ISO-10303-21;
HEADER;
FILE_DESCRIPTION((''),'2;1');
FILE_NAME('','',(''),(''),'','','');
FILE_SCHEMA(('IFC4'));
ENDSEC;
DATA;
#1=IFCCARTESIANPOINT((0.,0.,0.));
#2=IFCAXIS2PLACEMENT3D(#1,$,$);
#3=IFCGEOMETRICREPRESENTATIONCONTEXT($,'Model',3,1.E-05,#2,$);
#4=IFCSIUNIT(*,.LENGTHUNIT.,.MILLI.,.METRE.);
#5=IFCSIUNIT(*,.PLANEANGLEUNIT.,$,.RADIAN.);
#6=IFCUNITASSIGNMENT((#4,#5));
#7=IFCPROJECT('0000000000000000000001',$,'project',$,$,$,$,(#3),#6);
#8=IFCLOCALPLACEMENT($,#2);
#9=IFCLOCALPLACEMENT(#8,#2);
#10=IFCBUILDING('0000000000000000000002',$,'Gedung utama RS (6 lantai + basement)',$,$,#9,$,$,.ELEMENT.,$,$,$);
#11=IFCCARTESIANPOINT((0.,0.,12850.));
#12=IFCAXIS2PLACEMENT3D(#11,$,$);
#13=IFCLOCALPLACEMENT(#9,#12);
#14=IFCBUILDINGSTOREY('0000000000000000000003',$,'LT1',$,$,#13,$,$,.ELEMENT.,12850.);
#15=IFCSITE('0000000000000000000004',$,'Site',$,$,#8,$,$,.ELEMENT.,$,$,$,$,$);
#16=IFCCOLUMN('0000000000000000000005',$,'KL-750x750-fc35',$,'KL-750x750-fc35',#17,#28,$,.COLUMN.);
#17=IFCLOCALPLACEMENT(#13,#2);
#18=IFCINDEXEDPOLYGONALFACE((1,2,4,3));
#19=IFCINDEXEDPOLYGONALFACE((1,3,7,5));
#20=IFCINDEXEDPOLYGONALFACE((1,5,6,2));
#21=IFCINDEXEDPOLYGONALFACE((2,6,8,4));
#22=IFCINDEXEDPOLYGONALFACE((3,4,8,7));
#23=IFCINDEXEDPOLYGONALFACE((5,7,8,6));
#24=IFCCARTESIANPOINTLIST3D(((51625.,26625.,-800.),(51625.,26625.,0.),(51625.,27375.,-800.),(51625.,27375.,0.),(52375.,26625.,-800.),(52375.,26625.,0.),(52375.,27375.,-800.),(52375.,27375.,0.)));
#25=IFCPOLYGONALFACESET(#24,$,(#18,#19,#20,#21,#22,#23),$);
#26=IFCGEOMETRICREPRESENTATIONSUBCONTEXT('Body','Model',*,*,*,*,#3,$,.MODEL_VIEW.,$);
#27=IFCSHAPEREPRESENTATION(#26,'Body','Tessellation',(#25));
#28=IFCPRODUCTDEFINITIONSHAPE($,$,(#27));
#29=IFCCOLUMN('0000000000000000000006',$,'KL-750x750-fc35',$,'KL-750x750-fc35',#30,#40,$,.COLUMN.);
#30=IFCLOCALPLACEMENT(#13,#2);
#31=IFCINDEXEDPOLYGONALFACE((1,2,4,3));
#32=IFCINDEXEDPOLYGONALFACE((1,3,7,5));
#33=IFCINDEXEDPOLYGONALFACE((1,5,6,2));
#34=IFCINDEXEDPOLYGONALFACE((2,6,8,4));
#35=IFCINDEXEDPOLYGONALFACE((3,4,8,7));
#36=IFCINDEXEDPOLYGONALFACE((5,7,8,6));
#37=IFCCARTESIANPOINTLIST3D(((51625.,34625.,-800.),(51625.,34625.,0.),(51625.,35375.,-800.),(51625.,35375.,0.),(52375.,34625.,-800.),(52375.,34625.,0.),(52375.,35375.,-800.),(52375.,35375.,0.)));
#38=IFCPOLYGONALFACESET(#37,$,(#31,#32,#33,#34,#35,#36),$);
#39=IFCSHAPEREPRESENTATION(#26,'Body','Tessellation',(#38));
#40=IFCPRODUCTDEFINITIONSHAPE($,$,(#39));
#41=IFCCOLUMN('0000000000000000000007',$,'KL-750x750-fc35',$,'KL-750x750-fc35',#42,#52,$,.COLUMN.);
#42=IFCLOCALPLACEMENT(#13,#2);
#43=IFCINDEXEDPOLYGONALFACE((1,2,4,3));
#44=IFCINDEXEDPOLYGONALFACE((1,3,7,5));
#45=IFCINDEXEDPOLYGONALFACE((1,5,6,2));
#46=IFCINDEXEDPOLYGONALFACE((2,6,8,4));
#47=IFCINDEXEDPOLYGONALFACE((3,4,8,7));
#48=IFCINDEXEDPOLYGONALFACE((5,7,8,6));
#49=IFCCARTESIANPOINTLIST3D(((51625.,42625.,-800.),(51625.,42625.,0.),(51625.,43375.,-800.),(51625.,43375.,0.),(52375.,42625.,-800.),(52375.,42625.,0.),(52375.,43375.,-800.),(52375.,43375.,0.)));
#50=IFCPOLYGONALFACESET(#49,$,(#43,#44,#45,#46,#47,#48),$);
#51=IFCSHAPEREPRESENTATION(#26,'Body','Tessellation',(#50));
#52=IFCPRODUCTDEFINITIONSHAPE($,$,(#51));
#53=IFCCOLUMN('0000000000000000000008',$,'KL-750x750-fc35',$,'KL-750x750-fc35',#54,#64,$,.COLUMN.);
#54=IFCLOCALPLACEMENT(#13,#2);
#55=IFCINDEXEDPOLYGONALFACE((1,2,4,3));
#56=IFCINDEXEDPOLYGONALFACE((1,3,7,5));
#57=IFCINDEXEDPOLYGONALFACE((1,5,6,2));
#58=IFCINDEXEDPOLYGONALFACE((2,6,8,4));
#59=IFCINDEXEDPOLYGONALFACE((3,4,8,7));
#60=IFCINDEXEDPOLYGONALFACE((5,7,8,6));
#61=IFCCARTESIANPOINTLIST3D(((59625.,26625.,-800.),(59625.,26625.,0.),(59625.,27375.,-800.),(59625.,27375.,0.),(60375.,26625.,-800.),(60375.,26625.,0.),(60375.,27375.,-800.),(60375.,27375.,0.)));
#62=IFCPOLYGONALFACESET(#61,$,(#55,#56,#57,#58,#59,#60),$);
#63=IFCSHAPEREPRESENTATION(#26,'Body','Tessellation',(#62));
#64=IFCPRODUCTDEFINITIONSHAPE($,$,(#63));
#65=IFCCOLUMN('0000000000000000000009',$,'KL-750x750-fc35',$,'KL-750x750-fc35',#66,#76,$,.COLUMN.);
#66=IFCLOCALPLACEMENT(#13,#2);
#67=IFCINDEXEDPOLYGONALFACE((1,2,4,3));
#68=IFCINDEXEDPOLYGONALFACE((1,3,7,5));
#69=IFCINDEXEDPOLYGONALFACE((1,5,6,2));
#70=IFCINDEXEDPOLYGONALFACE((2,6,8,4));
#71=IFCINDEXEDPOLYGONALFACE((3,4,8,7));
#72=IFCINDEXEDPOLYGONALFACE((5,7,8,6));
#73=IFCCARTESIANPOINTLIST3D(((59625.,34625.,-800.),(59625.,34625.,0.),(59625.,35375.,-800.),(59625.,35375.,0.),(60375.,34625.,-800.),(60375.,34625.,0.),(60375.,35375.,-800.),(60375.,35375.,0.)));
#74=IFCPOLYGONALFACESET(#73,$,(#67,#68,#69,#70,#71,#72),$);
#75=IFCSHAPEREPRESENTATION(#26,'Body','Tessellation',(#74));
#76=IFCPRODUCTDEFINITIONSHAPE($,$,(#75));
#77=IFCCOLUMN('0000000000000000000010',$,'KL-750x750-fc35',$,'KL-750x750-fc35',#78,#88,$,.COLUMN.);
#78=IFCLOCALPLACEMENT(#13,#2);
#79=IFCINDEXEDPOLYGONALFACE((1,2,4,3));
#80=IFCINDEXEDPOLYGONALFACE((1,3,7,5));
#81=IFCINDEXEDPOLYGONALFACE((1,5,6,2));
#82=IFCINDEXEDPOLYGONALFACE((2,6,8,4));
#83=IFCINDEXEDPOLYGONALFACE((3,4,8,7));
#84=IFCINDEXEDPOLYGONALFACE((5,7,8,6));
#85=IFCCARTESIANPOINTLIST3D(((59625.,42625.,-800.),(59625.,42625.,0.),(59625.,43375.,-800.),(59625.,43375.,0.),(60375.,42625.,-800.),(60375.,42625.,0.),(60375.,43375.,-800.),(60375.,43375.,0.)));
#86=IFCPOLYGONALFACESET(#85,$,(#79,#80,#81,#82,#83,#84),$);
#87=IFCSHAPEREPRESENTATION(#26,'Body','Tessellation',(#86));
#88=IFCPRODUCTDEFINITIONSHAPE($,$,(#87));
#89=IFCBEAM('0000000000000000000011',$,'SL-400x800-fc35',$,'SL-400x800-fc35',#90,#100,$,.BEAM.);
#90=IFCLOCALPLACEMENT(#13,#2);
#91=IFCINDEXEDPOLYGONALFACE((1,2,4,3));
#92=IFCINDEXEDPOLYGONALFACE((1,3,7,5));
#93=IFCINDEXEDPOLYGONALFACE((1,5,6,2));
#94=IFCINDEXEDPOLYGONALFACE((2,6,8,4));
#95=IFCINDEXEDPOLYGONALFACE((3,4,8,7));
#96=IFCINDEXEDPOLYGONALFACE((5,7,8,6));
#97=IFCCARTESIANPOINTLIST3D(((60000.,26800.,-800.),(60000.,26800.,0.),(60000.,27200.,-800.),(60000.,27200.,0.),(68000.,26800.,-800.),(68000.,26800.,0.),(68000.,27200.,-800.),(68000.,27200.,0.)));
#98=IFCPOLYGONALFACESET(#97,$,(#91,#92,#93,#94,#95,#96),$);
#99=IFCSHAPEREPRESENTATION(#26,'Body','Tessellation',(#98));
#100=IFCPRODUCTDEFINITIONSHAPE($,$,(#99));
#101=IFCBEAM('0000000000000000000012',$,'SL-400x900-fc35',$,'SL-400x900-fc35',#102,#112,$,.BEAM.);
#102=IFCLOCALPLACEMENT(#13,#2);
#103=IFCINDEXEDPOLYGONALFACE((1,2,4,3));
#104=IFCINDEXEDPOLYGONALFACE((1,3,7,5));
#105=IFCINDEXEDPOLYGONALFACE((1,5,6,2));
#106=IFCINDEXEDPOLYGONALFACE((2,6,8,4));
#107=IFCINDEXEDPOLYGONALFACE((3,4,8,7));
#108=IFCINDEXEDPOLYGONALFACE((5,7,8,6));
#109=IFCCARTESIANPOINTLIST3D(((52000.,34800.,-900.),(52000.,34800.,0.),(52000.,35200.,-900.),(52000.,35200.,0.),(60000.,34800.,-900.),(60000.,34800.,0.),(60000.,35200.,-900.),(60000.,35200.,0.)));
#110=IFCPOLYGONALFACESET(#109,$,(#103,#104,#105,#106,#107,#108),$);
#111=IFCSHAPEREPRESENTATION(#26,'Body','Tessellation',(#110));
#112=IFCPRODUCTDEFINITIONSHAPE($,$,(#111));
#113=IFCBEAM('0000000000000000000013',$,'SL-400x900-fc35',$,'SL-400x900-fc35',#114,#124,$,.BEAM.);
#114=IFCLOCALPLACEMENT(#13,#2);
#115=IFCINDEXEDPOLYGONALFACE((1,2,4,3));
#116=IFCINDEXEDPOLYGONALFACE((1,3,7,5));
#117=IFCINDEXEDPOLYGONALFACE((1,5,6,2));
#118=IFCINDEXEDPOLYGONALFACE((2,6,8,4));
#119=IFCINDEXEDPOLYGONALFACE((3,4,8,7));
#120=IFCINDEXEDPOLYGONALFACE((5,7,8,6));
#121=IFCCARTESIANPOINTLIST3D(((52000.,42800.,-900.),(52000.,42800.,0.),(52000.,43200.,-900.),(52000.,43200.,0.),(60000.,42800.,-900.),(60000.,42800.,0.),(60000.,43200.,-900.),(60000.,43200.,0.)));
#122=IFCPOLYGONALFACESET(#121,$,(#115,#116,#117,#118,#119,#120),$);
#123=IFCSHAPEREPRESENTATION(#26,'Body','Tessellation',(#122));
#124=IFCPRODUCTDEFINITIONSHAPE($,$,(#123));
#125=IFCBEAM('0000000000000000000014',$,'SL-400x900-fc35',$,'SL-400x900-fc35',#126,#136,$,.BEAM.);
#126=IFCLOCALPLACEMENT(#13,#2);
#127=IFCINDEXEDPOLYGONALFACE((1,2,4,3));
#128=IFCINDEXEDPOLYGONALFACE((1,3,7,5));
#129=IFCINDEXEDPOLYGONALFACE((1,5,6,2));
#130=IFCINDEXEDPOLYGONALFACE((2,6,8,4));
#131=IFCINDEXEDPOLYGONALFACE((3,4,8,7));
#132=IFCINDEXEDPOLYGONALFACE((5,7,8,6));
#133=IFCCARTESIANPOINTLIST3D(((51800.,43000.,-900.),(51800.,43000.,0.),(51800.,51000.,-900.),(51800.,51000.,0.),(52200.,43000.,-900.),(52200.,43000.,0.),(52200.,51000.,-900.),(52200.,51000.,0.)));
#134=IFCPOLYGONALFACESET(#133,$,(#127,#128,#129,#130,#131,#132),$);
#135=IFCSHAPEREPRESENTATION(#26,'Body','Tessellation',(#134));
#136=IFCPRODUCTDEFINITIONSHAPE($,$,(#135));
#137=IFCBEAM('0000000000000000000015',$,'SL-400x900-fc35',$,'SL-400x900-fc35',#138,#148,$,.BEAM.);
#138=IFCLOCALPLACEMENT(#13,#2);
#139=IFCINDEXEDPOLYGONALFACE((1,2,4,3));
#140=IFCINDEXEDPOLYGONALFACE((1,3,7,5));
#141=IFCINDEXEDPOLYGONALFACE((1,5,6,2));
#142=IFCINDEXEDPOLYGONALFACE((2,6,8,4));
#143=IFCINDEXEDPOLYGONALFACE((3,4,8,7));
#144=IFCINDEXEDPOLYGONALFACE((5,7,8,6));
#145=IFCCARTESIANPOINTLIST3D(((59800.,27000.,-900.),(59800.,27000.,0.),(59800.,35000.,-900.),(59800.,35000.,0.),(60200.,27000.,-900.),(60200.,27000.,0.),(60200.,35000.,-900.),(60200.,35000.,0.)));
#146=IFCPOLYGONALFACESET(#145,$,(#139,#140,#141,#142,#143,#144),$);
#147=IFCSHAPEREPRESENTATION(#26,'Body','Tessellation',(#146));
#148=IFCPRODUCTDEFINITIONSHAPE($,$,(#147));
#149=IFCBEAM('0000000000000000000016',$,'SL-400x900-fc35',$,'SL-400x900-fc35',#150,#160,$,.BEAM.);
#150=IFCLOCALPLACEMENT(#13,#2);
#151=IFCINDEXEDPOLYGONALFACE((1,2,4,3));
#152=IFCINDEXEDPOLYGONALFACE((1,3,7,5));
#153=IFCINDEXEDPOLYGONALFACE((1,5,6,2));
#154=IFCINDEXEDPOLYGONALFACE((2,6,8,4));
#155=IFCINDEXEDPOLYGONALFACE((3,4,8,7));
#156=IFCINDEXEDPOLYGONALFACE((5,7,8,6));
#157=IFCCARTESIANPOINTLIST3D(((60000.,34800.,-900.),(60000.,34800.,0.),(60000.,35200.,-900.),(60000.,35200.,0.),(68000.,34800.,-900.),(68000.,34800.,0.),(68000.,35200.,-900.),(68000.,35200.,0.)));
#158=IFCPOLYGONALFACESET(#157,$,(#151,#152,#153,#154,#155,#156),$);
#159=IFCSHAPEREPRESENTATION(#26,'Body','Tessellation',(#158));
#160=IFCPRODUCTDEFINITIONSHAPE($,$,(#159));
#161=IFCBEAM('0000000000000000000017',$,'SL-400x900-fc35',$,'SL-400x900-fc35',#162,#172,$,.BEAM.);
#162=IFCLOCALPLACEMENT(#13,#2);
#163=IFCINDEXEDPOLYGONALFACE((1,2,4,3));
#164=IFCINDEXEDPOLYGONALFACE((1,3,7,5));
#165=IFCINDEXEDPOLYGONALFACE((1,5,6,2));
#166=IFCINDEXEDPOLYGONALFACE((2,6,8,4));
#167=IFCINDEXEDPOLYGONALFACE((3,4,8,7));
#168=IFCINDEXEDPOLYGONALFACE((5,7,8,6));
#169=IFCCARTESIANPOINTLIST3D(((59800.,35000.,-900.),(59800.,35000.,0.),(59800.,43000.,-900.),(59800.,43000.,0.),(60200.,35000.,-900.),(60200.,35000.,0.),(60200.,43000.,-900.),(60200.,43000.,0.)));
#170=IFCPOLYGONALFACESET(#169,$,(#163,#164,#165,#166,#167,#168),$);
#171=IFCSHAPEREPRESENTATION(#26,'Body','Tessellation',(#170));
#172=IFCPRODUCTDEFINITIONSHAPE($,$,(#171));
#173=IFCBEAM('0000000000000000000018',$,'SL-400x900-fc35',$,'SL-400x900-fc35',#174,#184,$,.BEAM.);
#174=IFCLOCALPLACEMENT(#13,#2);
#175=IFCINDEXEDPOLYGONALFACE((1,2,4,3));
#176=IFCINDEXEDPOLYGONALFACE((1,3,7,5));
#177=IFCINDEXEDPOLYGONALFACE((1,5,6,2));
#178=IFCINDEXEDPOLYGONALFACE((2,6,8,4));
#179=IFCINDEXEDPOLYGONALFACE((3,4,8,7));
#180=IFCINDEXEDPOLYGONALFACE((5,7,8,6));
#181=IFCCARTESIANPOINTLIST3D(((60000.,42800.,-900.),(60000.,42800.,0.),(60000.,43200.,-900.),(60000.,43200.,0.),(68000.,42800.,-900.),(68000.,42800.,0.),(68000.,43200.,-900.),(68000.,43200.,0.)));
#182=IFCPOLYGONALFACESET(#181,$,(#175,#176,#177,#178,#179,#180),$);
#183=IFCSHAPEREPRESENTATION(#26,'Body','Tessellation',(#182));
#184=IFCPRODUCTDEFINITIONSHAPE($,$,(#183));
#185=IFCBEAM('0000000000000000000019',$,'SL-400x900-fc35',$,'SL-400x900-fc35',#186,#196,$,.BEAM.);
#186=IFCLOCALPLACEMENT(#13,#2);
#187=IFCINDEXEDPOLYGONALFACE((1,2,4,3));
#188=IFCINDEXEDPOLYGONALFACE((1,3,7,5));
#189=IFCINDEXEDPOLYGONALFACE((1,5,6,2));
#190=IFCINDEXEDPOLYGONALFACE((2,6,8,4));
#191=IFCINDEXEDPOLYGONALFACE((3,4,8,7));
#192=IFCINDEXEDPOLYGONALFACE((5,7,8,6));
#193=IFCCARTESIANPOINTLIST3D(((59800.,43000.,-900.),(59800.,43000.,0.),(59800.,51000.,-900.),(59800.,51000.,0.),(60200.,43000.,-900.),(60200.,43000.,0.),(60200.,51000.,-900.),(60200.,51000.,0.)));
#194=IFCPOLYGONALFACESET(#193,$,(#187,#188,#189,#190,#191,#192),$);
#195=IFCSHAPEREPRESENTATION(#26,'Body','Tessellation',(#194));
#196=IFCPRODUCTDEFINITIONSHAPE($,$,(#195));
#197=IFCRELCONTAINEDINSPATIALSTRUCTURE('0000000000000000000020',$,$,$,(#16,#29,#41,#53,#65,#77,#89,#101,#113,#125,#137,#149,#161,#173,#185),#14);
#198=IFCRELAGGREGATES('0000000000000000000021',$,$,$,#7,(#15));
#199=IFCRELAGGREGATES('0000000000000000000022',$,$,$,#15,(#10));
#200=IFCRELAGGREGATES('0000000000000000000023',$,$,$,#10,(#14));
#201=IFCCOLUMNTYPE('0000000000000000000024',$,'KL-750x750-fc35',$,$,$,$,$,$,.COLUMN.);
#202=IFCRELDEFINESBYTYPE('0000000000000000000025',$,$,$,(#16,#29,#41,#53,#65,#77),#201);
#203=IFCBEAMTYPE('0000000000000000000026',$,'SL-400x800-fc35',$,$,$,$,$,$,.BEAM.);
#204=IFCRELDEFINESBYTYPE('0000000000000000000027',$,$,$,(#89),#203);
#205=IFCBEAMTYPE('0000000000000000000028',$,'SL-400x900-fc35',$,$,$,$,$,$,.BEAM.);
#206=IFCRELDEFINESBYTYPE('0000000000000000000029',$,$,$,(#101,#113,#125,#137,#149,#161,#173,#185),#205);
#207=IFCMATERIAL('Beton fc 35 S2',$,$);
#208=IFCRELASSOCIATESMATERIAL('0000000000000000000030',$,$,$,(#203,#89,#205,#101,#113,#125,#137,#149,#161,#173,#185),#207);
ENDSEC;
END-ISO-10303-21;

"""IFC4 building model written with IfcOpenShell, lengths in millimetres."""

from ifc_helpers import new_model, si_unit, frame, origin, origin_2d, place, context, subcontext, project, spatial, rectangle, extrude, material, material_profile, profile_set, profile_usage, type_object, element, save


model = new_model("IFC4")

# Units and contexts
model_context = context("Model", 3, precision=1e-05, world=origin())
body_context = subcontext(model_context, "Body", "Model", "MODEL_VIEW")
ifc_project = project(units=[si_unit("LENGTHUNIT", "METRE", prefix="MILLI"), si_unit("PLANEANGLEUNIT", "RADIAN")], contexts=[model_context])

# Site, building, storey
site_placement = place(None, origin())
site = spatial("IfcSite", under=ifc_project, at=site_placement, Name="Site", CompositionType="ELEMENT")
building_placement = place(site_placement, origin())
building = spatial("IfcBuilding", under=site, at=building_placement, Name="Gedung utama RS (6 lantai + basement)", CompositionType="ELEMENT")
storey_placement = place(building_placement, frame((0.0, 0.0, 12850.0)))
storey = spatial("IfcBuildingStorey", under=building, at=storey_placement, Name="LT1", CompositionType="ELEMENT", Elevation=12850.0)

# Columns
ifc_material_profile_1 = material_profile(None, rectangle(XDim=750.0, YDim=750.0, at=origin_2d()), Name="KL-750x750-fc35")
ifc_profile_set_1 = profile_set([ifc_material_profile_1], Name="KL-750x750-fc35")
ifc_profile_usage_1 = profile_usage(ifc_profile_set_1, cardinal=5)
column_type = type_object("IfcColumnType", Name="KL-750x750-fc35", PredefinedType="COLUMN", material=ifc_profile_set_1)
for number, where, z_axis, x_axis, name in (
    (1, (52000.0, 27000.0, -800.0), (0.0, 0.0, 1.0), (1.0, 0.0, 0.0), "KL-750x750-fc35"),
    (2, (52000.0, 35000.0, -800.0), (0.0, 0.0, 1.0), (1.0, 0.0, 0.0), "KL-750x750-fc35"),
    (3, (52000.0, 43000.0, -800.0), (0.0, 0.0, 1.0), (1.0, 0.0, 0.0), "KL-750x750-fc35"),
    (4, (60000.0, 27000.0, -800.0), (0.0, 0.0, 1.0), (1.0, 0.0, 0.0), "KL-750x750-fc35"),
    (5, (60000.0, 35000.0, -800.0), (0.0, 0.0, 1.0), (1.0, 0.0, 0.0), "KL-750x750-fc35"),
    (6, (60000.0, 43000.0, -800.0), (0.0, 0.0, 1.0), (1.0, 0.0, 0.0), "KL-750x750-fc35"),
):
    element("IfcColumn", number, at=place(storey_placement, frame(where, z_axis=z_axis, x_axis=x_axis)), inside=storey, type_object=column_type, material=ifc_profile_usage_1, Name=name, ObjectType="KL-750x750-fc35", PredefinedType="COLUMN", context=body_context, shape_type="SweptSolid", body=[
        extrude(rectangle(XDim=750.0, YDim=750.0, at=origin_2d()), origin(), (0.0, 0.0, 1.0), 800.0),
    ])

# Beams
ifc_material = material(Name="Beton fc 35 S2")
ifc_material_profile_2 = material_profile(ifc_material, rectangle(XDim=400.0, YDim=800.0, at=origin_2d()), Name="SL-400x800-fc35")
ifc_profile_set_2 = profile_set([ifc_material_profile_2], Name="SL-400x800-fc35")
ifc_profile_usage_2 = profile_usage(ifc_profile_set_2, cardinal=8)
beam_type_1 = type_object("IfcBeamType", Name="SL-400x800-fc35", PredefinedType="BEAM", material=ifc_profile_set_2)
beam_1_placement = place(storey_placement, frame((60000.0, 27000.0, -400.0)))
element("IfcBeam", 7, at=beam_1_placement, inside=storey, type_object=beam_type_1, material=ifc_profile_usage_2, Name="SL-400x800-fc35", ObjectType="SL-400x800-fc35", PredefinedType="BEAM", context=body_context, shape_type="SweptSolid", body=[
    extrude(rectangle(XDim=400.0, YDim=800.0, at=origin_2d()), frame((0.0, 0.0, 0.0), z_axis=(1.0, 0.0, 0.0), x_axis=(0.0, 1.0, 0.0)), (0.0, 0.0, 1.0), 8000.0),
])
ifc_material_profile_3 = material_profile(ifc_material, rectangle(XDim=400.0, YDim=900.0, at=origin_2d()), Name="SL-400x900-fc35")
ifc_profile_set_3 = profile_set([ifc_material_profile_3], Name="SL-400x900-fc35")
ifc_profile_usage_3 = profile_usage(ifc_profile_set_3, cardinal=8)
beam_type_2 = type_object("IfcBeamType", Name="SL-400x900-fc35", PredefinedType="BEAM", material=ifc_profile_set_3)
for number, where, name in (
    (8, (52000.0, 35000.0, -450.0), "SL-400x900-fc35"),
    (9, (52000.0, 43000.0, -450.0), "SL-400x900-fc35"),
):
    element("IfcBeam", number, at=place(storey_placement, frame(where)), inside=storey, type_object=beam_type_2, material=ifc_profile_usage_3, Name=name, ObjectType="SL-400x900-fc35", PredefinedType="BEAM", context=body_context, shape_type="SweptSolid", body=[
        extrude(rectangle(XDim=400.0, YDim=900.0, at=origin_2d()), frame((0.0, 0.0, 0.0), z_axis=(1.0, 0.0, 0.0), x_axis=(0.0, 1.0, 0.0)), (0.0, 0.0, 1.0), 8000.0),
    ])
for number, where, name in (
    (10, (52000.0, 43000.0, -450.0), "SL-400x900-fc35"),
    (11, (60000.0, 27000.0, -450.0), "SL-400x900-fc35"),
):
    element("IfcBeam", number, at=place(storey_placement, frame(where)), inside=storey, type_object=beam_type_2, material=ifc_profile_usage_3, Name=name, ObjectType="SL-400x900-fc35", PredefinedType="BEAM", context=body_context, shape_type="SweptSolid", body=[
        extrude(rectangle(XDim=400.0, YDim=900.0, at=origin_2d()), frame((0.0, 0.0, 0.0), z_axis=(0.0, 1.0, 0.0), x_axis=(-1.0, 0.0, 0.0)), (0.0, 0.0, 1.0), 8000.0),
    ])
beam_2_placement = place(storey_placement, frame((60000.0, 35000.0, -450.0)))
element("IfcBeam", 12, at=beam_2_placement, inside=storey, type_object=beam_type_2, material=ifc_profile_usage_3, Name="SL-400x900-fc35", ObjectType="SL-400x900-fc35", PredefinedType="BEAM", context=body_context, shape_type="SweptSolid", body=[
    extrude(rectangle(XDim=400.0, YDim=900.0, at=origin_2d()), frame((0.0, 0.0, 0.0), z_axis=(1.0, 0.0, 0.0), x_axis=(0.0, 1.0, 0.0)), (0.0, 0.0, 1.0), 8000.0),
])
beam_3_placement = place(storey_placement, frame((60000.0, 35000.0, -450.0)))
element("IfcBeam", 13, at=beam_3_placement, inside=storey, type_object=beam_type_2, material=ifc_profile_usage_3, Name="SL-400x900-fc35", ObjectType="SL-400x900-fc35", PredefinedType="BEAM", context=body_context, shape_type="SweptSolid", body=[
    extrude(rectangle(XDim=400.0, YDim=900.0, at=origin_2d()), frame((0.0, 0.0, 0.0), z_axis=(0.0, 1.0, 0.0), x_axis=(-1.0, 0.0, 0.0)), (0.0, 0.0, 1.0), 8000.0),
])
beam_4_placement = place(storey_placement, frame((60000.0, 43000.0, -450.0)))
element("IfcBeam", 14, at=beam_4_placement, inside=storey, type_object=beam_type_2, material=ifc_profile_usage_3, Name="SL-400x900-fc35", ObjectType="SL-400x900-fc35", PredefinedType="BEAM", context=body_context, shape_type="SweptSolid", body=[
    extrude(rectangle(XDim=400.0, YDim=900.0, at=origin_2d()), frame((0.0, 0.0, 0.0), z_axis=(1.0, 0.0, 0.0), x_axis=(0.0, 1.0, 0.0)), (0.0, 0.0, 1.0), 8000.0),
])
beam_5_placement = place(storey_placement, frame((60000.0, 43000.0, -450.0)))
element("IfcBeam", 15, at=beam_5_placement, inside=storey, type_object=beam_type_2, material=ifc_profile_usage_3, Name="SL-400x900-fc35", ObjectType="SL-400x900-fc35", PredefinedType="BEAM", context=body_context, shape_type="SweptSolid", body=[
    extrude(rectangle(XDim=400.0, YDim=900.0, at=origin_2d()), frame((0.0, 0.0, 0.0), z_axis=(0.0, 1.0, 0.0), x_axis=(-1.0, 0.0, 0.0)), (0.0, 0.0, 1.0), 8000.0),
])

save(model, "model.ifc")
